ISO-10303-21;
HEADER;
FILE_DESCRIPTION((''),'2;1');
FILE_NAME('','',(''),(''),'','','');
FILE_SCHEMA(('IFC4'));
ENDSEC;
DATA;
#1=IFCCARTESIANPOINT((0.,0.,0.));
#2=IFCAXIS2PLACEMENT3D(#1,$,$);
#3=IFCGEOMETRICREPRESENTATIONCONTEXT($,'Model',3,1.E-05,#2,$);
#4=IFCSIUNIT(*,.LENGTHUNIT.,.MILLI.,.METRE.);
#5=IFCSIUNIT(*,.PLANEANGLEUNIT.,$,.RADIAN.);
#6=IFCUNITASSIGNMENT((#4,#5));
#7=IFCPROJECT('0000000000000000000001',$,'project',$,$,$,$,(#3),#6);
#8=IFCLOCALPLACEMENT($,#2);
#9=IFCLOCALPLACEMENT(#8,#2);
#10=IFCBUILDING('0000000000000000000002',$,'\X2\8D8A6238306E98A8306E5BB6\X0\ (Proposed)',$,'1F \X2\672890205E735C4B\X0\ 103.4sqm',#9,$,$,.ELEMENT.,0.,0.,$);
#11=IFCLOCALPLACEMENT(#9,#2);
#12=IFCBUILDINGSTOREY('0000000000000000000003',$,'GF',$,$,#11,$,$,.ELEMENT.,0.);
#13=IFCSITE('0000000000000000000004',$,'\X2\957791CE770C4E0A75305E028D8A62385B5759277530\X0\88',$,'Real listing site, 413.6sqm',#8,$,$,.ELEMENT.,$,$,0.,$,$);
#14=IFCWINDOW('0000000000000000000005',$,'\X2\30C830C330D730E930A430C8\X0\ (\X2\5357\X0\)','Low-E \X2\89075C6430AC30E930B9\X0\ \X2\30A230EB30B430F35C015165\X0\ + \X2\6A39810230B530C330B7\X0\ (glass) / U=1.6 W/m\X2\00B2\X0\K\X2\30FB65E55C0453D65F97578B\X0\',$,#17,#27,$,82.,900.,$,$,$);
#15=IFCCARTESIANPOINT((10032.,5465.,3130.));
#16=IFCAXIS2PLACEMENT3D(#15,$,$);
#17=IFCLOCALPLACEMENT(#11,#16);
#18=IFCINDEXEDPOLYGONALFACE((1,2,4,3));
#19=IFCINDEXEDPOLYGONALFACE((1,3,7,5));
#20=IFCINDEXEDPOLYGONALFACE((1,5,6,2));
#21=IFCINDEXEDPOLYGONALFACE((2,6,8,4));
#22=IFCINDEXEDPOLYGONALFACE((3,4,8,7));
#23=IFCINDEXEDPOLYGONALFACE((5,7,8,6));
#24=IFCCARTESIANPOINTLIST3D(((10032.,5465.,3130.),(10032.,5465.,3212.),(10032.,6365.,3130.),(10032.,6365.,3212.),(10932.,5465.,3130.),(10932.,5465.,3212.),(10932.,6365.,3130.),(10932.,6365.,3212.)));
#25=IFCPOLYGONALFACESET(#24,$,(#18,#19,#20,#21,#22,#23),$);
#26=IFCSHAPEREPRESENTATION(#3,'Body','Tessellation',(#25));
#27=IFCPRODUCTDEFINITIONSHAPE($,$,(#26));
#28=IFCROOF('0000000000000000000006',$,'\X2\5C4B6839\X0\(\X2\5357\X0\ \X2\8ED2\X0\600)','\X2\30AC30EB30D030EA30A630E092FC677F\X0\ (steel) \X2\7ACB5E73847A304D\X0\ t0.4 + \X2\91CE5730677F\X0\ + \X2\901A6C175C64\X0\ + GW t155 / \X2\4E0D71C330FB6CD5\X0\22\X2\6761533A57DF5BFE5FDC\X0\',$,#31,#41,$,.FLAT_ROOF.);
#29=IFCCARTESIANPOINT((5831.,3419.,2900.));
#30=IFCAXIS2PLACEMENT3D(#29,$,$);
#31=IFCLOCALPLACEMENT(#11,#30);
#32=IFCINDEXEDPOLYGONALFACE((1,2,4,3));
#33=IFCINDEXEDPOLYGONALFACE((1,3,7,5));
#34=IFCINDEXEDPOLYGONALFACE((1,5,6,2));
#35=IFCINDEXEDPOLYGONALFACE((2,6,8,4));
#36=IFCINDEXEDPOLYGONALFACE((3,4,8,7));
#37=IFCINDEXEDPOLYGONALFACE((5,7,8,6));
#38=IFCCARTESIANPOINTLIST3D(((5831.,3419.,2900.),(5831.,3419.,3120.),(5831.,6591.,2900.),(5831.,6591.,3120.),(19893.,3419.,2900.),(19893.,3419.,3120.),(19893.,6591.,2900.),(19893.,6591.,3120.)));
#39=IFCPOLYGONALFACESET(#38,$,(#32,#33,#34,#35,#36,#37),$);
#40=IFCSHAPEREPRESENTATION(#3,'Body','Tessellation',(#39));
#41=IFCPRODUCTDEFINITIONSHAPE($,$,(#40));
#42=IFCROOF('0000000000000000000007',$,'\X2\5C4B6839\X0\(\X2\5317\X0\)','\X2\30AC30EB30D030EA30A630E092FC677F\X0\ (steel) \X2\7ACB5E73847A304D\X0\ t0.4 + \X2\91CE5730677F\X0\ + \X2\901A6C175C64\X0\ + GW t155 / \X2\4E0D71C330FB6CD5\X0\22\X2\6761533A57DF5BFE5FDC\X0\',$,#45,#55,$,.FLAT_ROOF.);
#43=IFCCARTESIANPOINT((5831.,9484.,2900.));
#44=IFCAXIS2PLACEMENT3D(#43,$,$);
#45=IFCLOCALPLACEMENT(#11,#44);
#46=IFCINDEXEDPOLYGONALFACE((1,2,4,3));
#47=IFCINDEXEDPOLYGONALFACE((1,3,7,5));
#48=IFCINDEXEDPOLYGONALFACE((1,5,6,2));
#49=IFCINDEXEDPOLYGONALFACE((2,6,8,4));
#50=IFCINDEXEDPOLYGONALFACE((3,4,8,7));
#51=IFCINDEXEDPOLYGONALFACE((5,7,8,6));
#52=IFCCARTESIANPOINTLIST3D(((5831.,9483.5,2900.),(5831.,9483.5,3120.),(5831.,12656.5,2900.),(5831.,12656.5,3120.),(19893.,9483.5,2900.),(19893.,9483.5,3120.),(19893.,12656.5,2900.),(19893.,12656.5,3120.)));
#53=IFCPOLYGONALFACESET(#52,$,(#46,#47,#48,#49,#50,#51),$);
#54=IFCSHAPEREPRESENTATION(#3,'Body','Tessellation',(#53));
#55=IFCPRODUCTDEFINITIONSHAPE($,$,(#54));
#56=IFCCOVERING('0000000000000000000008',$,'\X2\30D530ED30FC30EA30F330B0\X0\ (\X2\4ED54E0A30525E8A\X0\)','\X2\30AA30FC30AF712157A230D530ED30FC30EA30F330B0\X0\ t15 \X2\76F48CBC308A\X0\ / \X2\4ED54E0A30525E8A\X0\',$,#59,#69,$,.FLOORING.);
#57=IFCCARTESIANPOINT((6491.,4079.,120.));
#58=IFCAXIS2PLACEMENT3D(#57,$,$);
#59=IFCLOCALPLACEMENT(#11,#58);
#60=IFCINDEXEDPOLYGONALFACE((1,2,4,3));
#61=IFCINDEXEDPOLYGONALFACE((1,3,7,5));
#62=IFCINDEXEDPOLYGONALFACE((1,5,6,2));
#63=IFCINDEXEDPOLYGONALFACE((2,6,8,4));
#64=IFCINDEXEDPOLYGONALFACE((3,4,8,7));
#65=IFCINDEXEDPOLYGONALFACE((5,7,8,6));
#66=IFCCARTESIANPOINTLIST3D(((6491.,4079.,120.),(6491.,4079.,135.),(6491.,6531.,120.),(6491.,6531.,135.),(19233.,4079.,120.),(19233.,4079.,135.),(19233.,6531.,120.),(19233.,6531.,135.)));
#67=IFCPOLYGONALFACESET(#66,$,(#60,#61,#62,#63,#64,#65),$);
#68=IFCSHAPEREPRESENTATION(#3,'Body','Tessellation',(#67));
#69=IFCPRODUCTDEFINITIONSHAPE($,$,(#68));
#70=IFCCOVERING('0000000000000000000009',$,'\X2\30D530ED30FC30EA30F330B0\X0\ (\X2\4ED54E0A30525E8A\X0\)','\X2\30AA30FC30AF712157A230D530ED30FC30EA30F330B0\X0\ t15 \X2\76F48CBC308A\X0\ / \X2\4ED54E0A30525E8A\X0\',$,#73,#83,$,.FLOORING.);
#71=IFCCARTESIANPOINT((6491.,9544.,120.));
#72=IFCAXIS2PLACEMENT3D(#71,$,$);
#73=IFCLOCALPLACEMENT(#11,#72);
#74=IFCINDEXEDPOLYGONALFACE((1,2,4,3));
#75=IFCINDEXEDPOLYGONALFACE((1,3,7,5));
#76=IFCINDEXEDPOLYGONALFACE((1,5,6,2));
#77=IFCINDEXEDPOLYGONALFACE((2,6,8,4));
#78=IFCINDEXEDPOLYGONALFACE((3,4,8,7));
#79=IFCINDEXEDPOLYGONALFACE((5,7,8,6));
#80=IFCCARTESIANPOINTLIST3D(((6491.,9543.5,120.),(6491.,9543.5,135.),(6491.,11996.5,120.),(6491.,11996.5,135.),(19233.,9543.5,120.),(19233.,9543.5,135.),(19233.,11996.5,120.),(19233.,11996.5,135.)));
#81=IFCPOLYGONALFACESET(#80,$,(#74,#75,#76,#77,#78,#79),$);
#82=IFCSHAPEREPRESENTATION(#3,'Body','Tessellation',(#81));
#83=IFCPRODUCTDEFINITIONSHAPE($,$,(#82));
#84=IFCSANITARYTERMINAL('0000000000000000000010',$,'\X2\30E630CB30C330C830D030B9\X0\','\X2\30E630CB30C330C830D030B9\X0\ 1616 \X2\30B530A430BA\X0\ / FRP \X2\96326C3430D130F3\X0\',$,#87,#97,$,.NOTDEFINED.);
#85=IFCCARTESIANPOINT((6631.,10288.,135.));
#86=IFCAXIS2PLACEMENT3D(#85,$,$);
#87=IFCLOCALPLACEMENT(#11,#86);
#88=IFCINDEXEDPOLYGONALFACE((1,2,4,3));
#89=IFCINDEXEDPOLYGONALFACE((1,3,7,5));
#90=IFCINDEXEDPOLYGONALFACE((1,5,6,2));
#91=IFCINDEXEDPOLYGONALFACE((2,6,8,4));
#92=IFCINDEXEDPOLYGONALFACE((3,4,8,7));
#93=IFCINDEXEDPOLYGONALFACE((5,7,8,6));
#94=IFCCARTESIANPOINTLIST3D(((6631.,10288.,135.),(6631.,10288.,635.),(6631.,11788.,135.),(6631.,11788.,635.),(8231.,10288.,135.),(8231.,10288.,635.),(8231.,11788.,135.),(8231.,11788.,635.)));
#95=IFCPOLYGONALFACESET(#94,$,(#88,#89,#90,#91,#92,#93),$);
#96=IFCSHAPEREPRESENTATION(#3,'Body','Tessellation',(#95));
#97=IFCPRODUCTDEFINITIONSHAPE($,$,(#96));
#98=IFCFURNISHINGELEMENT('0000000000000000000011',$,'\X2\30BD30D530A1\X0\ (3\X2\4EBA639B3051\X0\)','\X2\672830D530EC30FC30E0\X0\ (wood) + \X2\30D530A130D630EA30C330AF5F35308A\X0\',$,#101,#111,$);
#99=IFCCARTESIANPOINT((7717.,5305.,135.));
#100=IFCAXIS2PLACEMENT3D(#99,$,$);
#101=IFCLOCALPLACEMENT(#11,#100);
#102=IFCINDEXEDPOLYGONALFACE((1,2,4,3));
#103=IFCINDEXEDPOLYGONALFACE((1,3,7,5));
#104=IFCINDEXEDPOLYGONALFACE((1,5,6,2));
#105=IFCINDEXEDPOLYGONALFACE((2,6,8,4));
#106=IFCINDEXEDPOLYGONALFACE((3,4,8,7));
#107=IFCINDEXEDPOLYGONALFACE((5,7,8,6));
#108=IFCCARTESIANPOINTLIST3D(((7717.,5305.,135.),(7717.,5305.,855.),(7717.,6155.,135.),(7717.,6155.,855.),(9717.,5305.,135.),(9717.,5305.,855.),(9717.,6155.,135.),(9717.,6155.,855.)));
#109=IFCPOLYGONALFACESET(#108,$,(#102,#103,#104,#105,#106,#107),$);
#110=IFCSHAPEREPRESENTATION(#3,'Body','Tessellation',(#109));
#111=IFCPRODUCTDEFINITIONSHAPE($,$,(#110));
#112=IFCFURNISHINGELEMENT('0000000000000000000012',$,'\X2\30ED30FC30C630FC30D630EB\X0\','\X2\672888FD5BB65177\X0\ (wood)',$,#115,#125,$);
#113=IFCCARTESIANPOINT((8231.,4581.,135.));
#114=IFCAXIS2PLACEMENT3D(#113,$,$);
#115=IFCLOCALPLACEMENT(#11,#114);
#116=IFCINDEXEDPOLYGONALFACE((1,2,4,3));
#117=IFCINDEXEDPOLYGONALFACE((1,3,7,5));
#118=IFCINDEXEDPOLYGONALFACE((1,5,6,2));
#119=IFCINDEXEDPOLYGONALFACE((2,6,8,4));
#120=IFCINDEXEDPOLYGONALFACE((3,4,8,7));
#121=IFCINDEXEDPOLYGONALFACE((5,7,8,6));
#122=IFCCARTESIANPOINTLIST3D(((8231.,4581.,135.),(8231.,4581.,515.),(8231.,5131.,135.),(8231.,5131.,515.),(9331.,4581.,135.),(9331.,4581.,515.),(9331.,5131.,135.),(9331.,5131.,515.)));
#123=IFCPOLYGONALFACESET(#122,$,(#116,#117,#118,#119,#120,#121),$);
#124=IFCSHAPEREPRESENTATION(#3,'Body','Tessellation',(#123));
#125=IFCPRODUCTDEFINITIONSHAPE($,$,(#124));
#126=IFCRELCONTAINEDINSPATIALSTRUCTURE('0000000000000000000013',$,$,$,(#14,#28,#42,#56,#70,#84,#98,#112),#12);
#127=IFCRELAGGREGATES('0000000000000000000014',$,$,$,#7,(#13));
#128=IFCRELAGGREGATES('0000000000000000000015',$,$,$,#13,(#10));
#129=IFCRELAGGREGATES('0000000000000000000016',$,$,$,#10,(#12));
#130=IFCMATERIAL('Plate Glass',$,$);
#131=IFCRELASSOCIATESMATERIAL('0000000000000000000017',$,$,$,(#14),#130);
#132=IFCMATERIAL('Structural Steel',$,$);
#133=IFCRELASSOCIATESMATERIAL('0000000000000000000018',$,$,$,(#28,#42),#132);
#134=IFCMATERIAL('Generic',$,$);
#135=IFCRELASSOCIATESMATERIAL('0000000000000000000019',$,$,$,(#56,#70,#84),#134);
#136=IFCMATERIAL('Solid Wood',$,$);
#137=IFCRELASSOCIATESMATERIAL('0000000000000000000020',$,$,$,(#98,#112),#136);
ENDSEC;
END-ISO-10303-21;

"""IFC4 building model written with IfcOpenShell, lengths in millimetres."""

from ifc_helpers import new_model, si_unit, frame, frame_2d, origin, place, context, project, spatial, rectangle, extrude, material, element, save


model = new_model("IFC4")

# Units and contexts
model_context = context("Model", 3, precision=1e-05, world=origin())
ifc_project = project(units=[si_unit("LENGTHUNIT", "METRE", prefix="MILLI"), si_unit("PLANEANGLEUNIT", "RADIAN")], contexts=[model_context])

# Site, building, storey
site_placement = place(None, origin())
site = spatial("IfcSite", under=ifc_project, at=site_placement, Name="長野県上田市越戸字大田88", ObjectType="Real listing site, 413.6sqm", CompositionType="ELEMENT", RefElevation=0.0)
building_placement = place(site_placement, origin())
building = spatial("IfcBuilding", under=site, at=building_placement, Name="越戸の風の家 (Proposed)", ObjectType="1F 木造平屋 103.4sqm", CompositionType="ELEMENT", ElevationOfRefHeight=0.0, ElevationOfTerrain=0.0)
storey_placement = place(building_placement, origin())
storey = spatial("IfcBuildingStorey", under=building, at=storey_placement, Name="GF", CompositionType="ELEMENT", Elevation=0.0)

# Shared definitions
ifc_material_1 = material(Name="Solid Wood")

# Shared definitions
ifc_material_2 = material(Name="Plate Glass")

# Window
window_1_placement = place(storey_placement, frame((10032.0, 5465.0, 3130.0)))
element("IfcWindow", 1, at=window_1_placement, inside=storey, material=ifc_material_2, Name="トップライト (南)", Description="Low-E 複層ガラス アルゴン封入 + 樹脂サッシ (glass) / U=1.6 W/m²K・日射取得型", OverallHeight=82.0, OverallWidth=900.0, context=model_context, shape_type="SweptSolid", body=[
    extrude(rectangle(XDim=900.0, YDim=900.0, at=frame_2d((450.0, 450.0))), frame((10032.0, 5465.0, 3130.0)), (0.0, 0.0, 1.0), 82.0),
])

# Roofs
ifc_material_3 = material(Name="Structural Steel")
roof_1_placement = place(storey_placement, frame((5831.0, 3419.0, 2900.0)))
element("IfcRoof", 2, at=roof_1_placement, inside=storey, material=ifc_material_3, Name="屋根(南 軒600)", Description="ガルバリウム鋼板 (steel) 立平葺き t0.4 + 野地板 + 通気層 + GW t155 / 不燃・法22条区域対応", PredefinedType="FLAT_ROOF", context=model_context, shape_type="SweptSolid", body=[
    extrude(rectangle(XDim=14062.0, YDim=3172.0, at=frame_2d((7031.0, 1586.0))), frame((5831.0, 3419.0, 2900.0)), (0.0, 0.0, 1.0), 220.0),
])
roof_2_placement = place(storey_placement, frame((5831.0, 9484.0, 2900.0)))
element("IfcRoof", 3, at=roof_2_placement, inside=storey, material=ifc_material_3, Name="屋根(北)", Description="ガルバリウム鋼板 (steel) 立平葺き t0.4 + 野地板 + 通気層 + GW t155 / 不燃・法22条区域対応", PredefinedType="FLAT_ROOF", context=model_context, shape_type="SweptSolid", body=[
    extrude(rectangle(XDim=14062.0, YDim=3173.0, at=frame_2d((7031.0, 1586.0))), frame((5831.0, 9484.0, 2900.0)), (0.0, 0.0, 1.0), 220.0),
])

# Coverings
ifc_material_4 = material(Name="Generic")
covering_1_placement = place(storey_placement, frame((6491.0, 4079.0, 120.0)))
element("IfcCovering", 4, at=covering_1_placement, inside=storey, material=ifc_material_4, Name="フローリング (仕上げ床)", Description="オーク無垢フローリング t15 直貼り / 仕上げ床", PredefinedType="FLOORING", context=model_context, shape_type="SweptSolid", body=[
    extrude(rectangle(XDim=12742.0, YDim=2452.0, at=frame_2d((6371.0, 1226.0))), frame((6491.0, 4079.0, 120.0)), (0.0, 0.0, 1.0), 15.0),
])
covering_2_placement = place(storey_placement, frame((6491.0, 9544.0, 120.0)))
element("IfcCovering", 5, at=covering_2_placement, inside=storey, material=ifc_material_4, Name="フローリング (仕上げ床)", Description="オーク無垢フローリング t15 直貼り / 仕上げ床", PredefinedType="FLOORING", context=model_context, shape_type="SweptSolid", body=[
    extrude(rectangle(XDim=12742.0, YDim=2453.0, at=frame_2d((6371.0, 1226.0))), frame((6491.0, 9544.0, 120.0)), (0.0, 0.0, 1.0), 15.0),
])

# Sanitary terminal
sanitary_terminal_placement = place(storey_placement, frame((6631.0, 10288.0, 135.0)))
element("IfcSanitaryTerminal", 6, at=sanitary_terminal_placement, inside=storey, material=ifc_material_4, Name="ユニットバス", Description="ユニットバス 1616 サイズ / FRP 防水パン", PredefinedType="NOTDEFINED", context=model_context, shape_type="SweptSolid", body=[
    extrude(rectangle(XDim=1600.0, YDim=1500.0, at=frame_2d((800.0, 750.0))), frame((6631.0, 10288.0, 135.0)), (0.0, 0.0, 1.0), 500.0),
])

# Furnishing elements
furnishing_1_placement = place(storey_placement, frame((7717.0, 5305.0, 135.0)))
element("IfcFurnishingElement", 7, at=furnishing_1_placement, inside=storey, material=ifc_material_1, Name="ソファ (3人掛け)", Description="木フレーム (wood) + ファブリック張り", context=model_context, shape_type="SweptSolid", body=[
    extrude(rectangle(XDim=2000.0, YDim=850.0, at=frame_2d((1000.0, 425.0))), frame((7717.0, 5305.0, 135.0)), (0.0, 0.0, 1.0), 720.0),
])
furnishing_2_placement = place(storey_placement, frame((8231.0, 4581.0, 135.0)))
element("IfcFurnishingElement", 8, at=furnishing_2_placement, inside=storey, material=ifc_material_1, Name="ローテーブル", Description="木製家具 (wood)", context=model_context, shape_type="SweptSolid", body=[
    extrude(rectangle(XDim=1100.0, YDim=550.0, at=frame_2d((550.0, 275.0))), frame((8231.0, 4581.0, 135.0)), (0.0, 0.0, 1.0), 380.0),
])

save(model, "model.ifc")
